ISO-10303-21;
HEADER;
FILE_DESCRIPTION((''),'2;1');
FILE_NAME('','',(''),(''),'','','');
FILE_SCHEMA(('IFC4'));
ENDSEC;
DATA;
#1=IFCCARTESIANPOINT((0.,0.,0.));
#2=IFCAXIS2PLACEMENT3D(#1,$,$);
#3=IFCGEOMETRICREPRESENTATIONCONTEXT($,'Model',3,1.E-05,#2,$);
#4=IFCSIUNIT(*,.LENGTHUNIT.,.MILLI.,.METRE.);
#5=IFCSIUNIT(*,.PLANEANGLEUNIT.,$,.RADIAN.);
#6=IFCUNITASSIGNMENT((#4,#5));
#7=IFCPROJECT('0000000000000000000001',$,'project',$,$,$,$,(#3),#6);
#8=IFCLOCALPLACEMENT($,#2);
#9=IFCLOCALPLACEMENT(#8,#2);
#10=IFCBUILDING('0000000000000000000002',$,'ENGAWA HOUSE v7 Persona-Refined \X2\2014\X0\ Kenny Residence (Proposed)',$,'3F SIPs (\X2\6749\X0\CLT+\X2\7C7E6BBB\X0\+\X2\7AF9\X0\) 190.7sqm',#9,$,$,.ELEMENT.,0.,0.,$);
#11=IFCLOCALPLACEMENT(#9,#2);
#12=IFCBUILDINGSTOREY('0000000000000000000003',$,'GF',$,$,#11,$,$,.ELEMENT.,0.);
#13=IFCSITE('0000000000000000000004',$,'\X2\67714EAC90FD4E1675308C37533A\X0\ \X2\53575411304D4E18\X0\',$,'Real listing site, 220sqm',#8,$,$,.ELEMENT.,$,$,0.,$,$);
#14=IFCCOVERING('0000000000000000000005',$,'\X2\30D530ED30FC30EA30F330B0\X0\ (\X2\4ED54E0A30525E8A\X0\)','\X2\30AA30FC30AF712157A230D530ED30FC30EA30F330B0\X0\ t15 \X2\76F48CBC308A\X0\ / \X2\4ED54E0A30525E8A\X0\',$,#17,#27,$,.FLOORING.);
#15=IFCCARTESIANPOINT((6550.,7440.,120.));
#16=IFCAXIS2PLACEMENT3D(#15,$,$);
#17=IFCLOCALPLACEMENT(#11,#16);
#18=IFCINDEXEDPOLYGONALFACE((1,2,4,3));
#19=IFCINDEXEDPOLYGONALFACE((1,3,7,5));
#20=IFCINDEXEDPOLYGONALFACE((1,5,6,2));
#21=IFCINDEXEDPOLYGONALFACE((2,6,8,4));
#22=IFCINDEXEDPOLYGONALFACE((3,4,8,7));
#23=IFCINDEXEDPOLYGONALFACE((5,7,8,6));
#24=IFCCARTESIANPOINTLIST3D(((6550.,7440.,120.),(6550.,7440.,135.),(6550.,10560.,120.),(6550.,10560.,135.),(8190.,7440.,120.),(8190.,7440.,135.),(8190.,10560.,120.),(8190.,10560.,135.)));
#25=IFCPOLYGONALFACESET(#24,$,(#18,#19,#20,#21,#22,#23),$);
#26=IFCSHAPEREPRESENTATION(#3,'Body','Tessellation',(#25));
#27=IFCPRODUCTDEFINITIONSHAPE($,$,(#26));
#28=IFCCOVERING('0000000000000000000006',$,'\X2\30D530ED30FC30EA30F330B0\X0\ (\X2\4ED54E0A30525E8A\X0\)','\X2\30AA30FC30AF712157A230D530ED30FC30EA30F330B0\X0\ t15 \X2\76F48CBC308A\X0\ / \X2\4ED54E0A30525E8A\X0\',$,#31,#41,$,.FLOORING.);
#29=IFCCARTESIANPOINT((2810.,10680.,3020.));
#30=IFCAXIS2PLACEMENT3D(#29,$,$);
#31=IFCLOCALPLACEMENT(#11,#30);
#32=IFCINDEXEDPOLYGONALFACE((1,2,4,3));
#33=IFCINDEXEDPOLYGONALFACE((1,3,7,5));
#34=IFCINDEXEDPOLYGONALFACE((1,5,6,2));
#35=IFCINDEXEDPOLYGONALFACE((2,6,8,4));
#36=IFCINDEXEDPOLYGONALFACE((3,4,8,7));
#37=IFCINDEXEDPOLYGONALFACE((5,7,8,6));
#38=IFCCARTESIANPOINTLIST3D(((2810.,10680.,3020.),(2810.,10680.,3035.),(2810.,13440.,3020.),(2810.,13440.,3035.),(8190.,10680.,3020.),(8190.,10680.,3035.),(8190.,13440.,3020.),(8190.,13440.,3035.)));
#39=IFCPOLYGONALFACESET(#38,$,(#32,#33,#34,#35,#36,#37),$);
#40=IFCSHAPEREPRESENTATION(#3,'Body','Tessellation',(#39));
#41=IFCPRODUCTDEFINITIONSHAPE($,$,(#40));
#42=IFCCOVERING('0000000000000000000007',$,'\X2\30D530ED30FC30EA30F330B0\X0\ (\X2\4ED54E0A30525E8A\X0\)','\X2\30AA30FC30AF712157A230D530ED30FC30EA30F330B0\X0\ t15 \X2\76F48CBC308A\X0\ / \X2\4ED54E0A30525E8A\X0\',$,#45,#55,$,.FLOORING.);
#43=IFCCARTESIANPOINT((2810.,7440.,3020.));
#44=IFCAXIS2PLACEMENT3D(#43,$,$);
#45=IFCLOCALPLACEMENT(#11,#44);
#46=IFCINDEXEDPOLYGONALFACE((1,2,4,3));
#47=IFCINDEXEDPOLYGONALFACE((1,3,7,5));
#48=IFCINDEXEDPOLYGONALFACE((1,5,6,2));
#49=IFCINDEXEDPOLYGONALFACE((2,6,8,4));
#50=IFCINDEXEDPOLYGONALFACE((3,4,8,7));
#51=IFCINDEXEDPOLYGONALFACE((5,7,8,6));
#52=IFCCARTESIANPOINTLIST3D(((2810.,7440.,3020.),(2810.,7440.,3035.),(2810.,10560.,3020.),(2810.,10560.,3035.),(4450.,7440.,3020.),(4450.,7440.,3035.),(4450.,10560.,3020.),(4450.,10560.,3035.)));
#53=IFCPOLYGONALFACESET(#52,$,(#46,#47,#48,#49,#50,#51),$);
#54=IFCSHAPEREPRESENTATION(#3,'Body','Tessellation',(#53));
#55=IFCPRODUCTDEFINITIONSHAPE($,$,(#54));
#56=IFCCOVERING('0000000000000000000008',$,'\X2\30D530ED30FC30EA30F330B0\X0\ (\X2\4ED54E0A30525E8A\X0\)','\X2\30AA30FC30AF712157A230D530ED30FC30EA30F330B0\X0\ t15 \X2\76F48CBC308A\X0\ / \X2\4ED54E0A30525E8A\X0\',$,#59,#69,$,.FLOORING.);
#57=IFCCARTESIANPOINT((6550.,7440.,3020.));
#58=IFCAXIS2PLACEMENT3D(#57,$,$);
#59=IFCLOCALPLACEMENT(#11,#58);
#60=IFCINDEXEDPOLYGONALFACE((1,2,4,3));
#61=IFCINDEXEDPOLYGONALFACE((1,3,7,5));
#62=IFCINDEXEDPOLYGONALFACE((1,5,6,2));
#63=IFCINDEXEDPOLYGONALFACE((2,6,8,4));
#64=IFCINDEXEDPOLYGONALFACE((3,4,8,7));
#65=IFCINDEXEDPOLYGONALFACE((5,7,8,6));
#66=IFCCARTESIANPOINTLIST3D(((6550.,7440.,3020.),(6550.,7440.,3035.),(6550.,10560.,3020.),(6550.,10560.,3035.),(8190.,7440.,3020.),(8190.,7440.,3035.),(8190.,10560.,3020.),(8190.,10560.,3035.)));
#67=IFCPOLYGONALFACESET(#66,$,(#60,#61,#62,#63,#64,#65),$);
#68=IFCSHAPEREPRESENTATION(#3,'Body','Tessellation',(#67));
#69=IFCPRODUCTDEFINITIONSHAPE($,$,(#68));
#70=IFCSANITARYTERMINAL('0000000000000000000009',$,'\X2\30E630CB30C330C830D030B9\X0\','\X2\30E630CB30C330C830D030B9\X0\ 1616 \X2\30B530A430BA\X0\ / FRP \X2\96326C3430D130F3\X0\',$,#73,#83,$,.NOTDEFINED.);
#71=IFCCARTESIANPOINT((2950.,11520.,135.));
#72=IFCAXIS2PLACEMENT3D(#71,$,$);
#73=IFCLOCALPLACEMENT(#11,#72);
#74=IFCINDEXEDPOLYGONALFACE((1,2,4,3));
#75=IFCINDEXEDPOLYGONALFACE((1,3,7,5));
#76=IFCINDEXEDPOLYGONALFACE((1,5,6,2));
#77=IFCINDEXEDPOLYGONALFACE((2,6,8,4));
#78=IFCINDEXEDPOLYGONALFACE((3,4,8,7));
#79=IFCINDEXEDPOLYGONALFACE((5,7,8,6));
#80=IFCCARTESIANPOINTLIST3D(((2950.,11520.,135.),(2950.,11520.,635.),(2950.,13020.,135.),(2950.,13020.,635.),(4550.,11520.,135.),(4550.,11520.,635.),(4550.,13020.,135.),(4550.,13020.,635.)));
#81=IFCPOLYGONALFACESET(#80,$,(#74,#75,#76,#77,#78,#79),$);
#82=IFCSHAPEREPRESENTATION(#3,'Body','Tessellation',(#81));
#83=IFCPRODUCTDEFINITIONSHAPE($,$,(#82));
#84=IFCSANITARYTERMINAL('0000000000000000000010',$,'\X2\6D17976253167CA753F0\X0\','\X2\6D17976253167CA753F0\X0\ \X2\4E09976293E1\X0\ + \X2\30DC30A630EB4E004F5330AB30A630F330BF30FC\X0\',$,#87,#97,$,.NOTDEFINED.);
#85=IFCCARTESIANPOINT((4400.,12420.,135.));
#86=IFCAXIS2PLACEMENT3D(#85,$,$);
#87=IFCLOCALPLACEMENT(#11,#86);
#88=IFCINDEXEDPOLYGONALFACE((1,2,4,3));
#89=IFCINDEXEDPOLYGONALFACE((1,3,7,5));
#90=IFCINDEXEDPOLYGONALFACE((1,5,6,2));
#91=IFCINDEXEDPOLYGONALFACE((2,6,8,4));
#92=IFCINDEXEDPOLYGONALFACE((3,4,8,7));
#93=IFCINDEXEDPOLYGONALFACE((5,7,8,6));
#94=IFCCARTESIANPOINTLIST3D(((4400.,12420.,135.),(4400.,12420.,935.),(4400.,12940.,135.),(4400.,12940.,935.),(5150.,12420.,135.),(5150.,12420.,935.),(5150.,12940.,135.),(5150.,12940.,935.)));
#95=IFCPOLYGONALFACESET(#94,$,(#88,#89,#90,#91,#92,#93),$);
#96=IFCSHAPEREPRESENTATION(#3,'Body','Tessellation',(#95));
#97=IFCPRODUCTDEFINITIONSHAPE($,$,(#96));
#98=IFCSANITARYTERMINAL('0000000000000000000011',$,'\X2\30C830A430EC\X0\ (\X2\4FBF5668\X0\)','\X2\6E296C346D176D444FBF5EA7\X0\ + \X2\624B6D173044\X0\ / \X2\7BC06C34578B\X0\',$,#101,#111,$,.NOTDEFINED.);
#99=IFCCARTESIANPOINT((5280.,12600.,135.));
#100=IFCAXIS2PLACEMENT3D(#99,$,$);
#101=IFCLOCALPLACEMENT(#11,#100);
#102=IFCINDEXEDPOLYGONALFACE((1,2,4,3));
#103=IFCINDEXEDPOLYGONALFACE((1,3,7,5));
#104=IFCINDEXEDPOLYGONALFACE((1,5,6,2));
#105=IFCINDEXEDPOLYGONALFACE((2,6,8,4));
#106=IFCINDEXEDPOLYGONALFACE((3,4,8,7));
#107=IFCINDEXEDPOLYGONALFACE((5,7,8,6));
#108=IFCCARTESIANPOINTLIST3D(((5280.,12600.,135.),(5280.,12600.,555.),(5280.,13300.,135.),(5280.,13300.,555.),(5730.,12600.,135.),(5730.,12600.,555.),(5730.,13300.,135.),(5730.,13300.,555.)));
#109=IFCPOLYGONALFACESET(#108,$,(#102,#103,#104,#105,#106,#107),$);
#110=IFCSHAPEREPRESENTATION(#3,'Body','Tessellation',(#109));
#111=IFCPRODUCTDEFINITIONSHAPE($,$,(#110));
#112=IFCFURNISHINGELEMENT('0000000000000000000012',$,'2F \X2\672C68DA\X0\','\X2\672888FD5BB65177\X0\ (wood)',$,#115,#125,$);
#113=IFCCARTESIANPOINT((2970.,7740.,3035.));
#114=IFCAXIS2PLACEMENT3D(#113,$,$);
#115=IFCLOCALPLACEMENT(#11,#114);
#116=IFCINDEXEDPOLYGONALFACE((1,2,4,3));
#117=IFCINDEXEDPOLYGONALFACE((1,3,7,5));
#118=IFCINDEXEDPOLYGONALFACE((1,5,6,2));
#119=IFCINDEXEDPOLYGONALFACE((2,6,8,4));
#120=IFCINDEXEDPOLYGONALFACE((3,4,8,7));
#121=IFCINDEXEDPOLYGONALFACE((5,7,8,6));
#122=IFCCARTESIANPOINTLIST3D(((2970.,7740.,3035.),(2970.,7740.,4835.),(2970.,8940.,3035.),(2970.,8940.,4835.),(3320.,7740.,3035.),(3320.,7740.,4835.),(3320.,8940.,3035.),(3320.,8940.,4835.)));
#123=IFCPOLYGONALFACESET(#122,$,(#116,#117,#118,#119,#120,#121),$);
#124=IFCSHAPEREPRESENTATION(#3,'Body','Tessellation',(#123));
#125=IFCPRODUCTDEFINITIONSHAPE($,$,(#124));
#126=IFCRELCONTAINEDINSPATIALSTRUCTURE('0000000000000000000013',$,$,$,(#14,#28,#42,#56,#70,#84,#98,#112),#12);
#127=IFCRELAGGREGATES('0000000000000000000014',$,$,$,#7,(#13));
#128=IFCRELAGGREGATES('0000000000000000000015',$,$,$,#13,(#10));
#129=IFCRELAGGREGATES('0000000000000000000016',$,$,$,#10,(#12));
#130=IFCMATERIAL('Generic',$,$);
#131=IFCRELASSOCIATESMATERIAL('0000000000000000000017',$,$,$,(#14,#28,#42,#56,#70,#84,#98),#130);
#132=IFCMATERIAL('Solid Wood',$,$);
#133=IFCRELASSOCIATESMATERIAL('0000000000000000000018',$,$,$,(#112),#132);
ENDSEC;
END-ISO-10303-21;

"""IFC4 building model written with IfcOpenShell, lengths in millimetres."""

from ifc_helpers import new_model, si_unit, frame, frame_2d, origin, place, context, project, spatial, rectangle, extrude, material, element, save


model = new_model("IFC4")

# Units and contexts
model_context = context("Model", 3, precision=1e-05, world=origin())
ifc_project = project(units=[si_unit("LENGTHUNIT", "METRE", prefix="MILLI"), si_unit("PLANEANGLEUNIT", "RADIAN")], contexts=[model_context])

# Site, building, storey
site_placement = place(None, origin())
site = spatial("IfcSite", under=ifc_project, at=site_placement, Name="東京都世田谷区 南向き丘", ObjectType="Real listing site, 220sqm", CompositionType="ELEMENT", RefElevation=0.0)
building_placement = place(site_placement, origin())
building = spatial("IfcBuilding", under=site, at=building_placement, Name="ENGAWA HOUSE v7 Persona-Refined — Kenny Residence (Proposed)", ObjectType="3F SIPs (杉CLT+籾殻+竹) 190.7sqm", CompositionType="ELEMENT", ElevationOfRefHeight=0.0, ElevationOfTerrain=0.0)
storey_placement = place(building_placement, origin())
storey = spatial("IfcBuildingStorey", under=building, at=storey_placement, Name="GF", CompositionType="ELEMENT", Elevation=0.0)

# Shared definitions
ifc_material_1 = material(Name="Solid Wood")

# Coverings
ifc_material_2 = material(Name="Generic")
covering_1_placement = place(storey_placement, frame((6550.0, 7440.0, 120.0)))
element("IfcCovering", 1, at=covering_1_placement, inside=storey, material=ifc_material_2, Name="フローリング (仕上げ床)", Description="オーク無垢フローリング t15 直貼り / 仕上げ床", PredefinedType="FLOORING", context=model_context, shape_type="SweptSolid", body=[
    extrude(rectangle(XDim=1640.0, YDim=3120.0, at=frame_2d((820.0, 1560.0))), frame((6550.0, 7440.0, 120.0)), (0.0, 0.0, 1.0), 15.0),
])
covering_2_placement = place(storey_placement, frame((2810.0, 10680.0, 3020.0)))
element("IfcCovering", 2, at=covering_2_placement, inside=storey, material=ifc_material_2, Name="フローリング (仕上げ床)", Description="オーク無垢フローリング t15 直貼り / 仕上げ床", PredefinedType="FLOORING", context=model_context, shape_type="SweptSolid", body=[
    extrude(rectangle(XDim=5380.0, YDim=2760.0, at=frame_2d((2690.0, 1380.0))), frame((2810.0, 10680.0, 3020.0)), (0.0, 0.0, 1.0), 15.0),
])
covering_3_placement = place(storey_placement, frame((2810.0, 7440.0, 3020.0)))
element("IfcCovering", 3, at=covering_3_placement, inside=storey, material=ifc_material_2, Name="フローリング (仕上げ床)", Description="オーク無垢フローリング t15 直貼り / 仕上げ床", PredefinedType="FLOORING", context=model_context, shape_type="SweptSolid", body=[
    extrude(rectangle(XDim=1640.0, YDim=3120.0, at=frame_2d((820.0, 1560.0))), frame((2810.0, 7440.0, 3020.0)), (0.0, 0.0, 1.0), 15.0),
])
covering_4_placement = place(storey_placement, frame((6550.0, 7440.0, 3020.0)))
element("IfcCovering", 4, at=covering_4_placement, inside=storey, material=ifc_material_2, Name="フローリング (仕上げ床)", Description="オーク無垢フローリング t15 直貼り / 仕上げ床", PredefinedType="FLOORING", context=model_context, shape_type="SweptSolid", body=[
    extrude(rectangle(XDim=1640.0, YDim=3120.0, at=frame_2d((820.0, 1560.0))), frame((6550.0, 7440.0, 3020.0)), (0.0, 0.0, 1.0), 15.0),
])

# Sanitary terminals
sanitary_terminal_1_placement = place(storey_placement, frame((2950.0, 11520.0, 135.0)))
element("IfcSanitaryTerminal", 5, at=sanitary_terminal_1_placement, inside=storey, material=ifc_material_2, Name="ユニットバス", Description="ユニットバス 1616 サイズ / FRP 防水パン", PredefinedType="NOTDEFINED", context=model_context, shape_type="SweptSolid", body=[
    extrude(rectangle(XDim=1600.0, YDim=1500.0, at=frame_2d((800.0, 750.0))), frame((2950.0, 11520.0, 135.0)), (0.0, 0.0, 1.0), 500.0),
])
sanitary_terminal_2_placement = place(storey_placement, frame((4400.0, 12420.0, 135.0)))
element("IfcSanitaryTerminal", 6, at=sanitary_terminal_2_placement, inside=storey, material=ifc_material_2, Name="洗面化粧台", Description="洗面化粧台 三面鏡 + ボウル一体カウンター", PredefinedType="NOTDEFINED", context=model_context, shape_type="SweptSolid", body=[
    extrude(rectangle(XDim=750.0, YDim=520.0, at=frame_2d((375.0, 260.0))), frame((4400.0, 12420.0, 135.0)), (0.0, 0.0, 1.0), 800.0),
])
sanitary_terminal_3_placement = place(storey_placement, frame((5280.0, 12600.0, 135.0)))
element("IfcSanitaryTerminal", 7, at=sanitary_terminal_3_placement, inside=storey, material=ifc_material_2, Name="トイレ (便器)", Description="温水洗浄便座 + 手洗い / 節水型", PredefinedType="NOTDEFINED", context=model_context, shape_type="SweptSolid", body=[
    extrude(rectangle(XDim=450.0, YDim=700.0, at=frame_2d((225.0, 350.0))), frame((5280.0, 12600.0, 135.0)), (0.0, 0.0, 1.0), 420.0),
])

# Furnishing element
furnishing_placement = place(storey_placement, frame((2970.0, 7740.0, 3035.0)))
element("IfcFurnishingElement", 8, at=furnishing_placement, inside=storey, material=ifc_material_1, Name="2F 本棚", Description="木製家具 (wood)", context=model_context, shape_type="SweptSolid", body=[
    extrude(rectangle(XDim=350.0, YDim=1200.0, at=frame_2d((175.0, 600.0))), frame((2970.0, 7740.0, 3035.0)), (0.0, 0.0, 1.0), 1800.0),
])

save(model, "model.ifc")
